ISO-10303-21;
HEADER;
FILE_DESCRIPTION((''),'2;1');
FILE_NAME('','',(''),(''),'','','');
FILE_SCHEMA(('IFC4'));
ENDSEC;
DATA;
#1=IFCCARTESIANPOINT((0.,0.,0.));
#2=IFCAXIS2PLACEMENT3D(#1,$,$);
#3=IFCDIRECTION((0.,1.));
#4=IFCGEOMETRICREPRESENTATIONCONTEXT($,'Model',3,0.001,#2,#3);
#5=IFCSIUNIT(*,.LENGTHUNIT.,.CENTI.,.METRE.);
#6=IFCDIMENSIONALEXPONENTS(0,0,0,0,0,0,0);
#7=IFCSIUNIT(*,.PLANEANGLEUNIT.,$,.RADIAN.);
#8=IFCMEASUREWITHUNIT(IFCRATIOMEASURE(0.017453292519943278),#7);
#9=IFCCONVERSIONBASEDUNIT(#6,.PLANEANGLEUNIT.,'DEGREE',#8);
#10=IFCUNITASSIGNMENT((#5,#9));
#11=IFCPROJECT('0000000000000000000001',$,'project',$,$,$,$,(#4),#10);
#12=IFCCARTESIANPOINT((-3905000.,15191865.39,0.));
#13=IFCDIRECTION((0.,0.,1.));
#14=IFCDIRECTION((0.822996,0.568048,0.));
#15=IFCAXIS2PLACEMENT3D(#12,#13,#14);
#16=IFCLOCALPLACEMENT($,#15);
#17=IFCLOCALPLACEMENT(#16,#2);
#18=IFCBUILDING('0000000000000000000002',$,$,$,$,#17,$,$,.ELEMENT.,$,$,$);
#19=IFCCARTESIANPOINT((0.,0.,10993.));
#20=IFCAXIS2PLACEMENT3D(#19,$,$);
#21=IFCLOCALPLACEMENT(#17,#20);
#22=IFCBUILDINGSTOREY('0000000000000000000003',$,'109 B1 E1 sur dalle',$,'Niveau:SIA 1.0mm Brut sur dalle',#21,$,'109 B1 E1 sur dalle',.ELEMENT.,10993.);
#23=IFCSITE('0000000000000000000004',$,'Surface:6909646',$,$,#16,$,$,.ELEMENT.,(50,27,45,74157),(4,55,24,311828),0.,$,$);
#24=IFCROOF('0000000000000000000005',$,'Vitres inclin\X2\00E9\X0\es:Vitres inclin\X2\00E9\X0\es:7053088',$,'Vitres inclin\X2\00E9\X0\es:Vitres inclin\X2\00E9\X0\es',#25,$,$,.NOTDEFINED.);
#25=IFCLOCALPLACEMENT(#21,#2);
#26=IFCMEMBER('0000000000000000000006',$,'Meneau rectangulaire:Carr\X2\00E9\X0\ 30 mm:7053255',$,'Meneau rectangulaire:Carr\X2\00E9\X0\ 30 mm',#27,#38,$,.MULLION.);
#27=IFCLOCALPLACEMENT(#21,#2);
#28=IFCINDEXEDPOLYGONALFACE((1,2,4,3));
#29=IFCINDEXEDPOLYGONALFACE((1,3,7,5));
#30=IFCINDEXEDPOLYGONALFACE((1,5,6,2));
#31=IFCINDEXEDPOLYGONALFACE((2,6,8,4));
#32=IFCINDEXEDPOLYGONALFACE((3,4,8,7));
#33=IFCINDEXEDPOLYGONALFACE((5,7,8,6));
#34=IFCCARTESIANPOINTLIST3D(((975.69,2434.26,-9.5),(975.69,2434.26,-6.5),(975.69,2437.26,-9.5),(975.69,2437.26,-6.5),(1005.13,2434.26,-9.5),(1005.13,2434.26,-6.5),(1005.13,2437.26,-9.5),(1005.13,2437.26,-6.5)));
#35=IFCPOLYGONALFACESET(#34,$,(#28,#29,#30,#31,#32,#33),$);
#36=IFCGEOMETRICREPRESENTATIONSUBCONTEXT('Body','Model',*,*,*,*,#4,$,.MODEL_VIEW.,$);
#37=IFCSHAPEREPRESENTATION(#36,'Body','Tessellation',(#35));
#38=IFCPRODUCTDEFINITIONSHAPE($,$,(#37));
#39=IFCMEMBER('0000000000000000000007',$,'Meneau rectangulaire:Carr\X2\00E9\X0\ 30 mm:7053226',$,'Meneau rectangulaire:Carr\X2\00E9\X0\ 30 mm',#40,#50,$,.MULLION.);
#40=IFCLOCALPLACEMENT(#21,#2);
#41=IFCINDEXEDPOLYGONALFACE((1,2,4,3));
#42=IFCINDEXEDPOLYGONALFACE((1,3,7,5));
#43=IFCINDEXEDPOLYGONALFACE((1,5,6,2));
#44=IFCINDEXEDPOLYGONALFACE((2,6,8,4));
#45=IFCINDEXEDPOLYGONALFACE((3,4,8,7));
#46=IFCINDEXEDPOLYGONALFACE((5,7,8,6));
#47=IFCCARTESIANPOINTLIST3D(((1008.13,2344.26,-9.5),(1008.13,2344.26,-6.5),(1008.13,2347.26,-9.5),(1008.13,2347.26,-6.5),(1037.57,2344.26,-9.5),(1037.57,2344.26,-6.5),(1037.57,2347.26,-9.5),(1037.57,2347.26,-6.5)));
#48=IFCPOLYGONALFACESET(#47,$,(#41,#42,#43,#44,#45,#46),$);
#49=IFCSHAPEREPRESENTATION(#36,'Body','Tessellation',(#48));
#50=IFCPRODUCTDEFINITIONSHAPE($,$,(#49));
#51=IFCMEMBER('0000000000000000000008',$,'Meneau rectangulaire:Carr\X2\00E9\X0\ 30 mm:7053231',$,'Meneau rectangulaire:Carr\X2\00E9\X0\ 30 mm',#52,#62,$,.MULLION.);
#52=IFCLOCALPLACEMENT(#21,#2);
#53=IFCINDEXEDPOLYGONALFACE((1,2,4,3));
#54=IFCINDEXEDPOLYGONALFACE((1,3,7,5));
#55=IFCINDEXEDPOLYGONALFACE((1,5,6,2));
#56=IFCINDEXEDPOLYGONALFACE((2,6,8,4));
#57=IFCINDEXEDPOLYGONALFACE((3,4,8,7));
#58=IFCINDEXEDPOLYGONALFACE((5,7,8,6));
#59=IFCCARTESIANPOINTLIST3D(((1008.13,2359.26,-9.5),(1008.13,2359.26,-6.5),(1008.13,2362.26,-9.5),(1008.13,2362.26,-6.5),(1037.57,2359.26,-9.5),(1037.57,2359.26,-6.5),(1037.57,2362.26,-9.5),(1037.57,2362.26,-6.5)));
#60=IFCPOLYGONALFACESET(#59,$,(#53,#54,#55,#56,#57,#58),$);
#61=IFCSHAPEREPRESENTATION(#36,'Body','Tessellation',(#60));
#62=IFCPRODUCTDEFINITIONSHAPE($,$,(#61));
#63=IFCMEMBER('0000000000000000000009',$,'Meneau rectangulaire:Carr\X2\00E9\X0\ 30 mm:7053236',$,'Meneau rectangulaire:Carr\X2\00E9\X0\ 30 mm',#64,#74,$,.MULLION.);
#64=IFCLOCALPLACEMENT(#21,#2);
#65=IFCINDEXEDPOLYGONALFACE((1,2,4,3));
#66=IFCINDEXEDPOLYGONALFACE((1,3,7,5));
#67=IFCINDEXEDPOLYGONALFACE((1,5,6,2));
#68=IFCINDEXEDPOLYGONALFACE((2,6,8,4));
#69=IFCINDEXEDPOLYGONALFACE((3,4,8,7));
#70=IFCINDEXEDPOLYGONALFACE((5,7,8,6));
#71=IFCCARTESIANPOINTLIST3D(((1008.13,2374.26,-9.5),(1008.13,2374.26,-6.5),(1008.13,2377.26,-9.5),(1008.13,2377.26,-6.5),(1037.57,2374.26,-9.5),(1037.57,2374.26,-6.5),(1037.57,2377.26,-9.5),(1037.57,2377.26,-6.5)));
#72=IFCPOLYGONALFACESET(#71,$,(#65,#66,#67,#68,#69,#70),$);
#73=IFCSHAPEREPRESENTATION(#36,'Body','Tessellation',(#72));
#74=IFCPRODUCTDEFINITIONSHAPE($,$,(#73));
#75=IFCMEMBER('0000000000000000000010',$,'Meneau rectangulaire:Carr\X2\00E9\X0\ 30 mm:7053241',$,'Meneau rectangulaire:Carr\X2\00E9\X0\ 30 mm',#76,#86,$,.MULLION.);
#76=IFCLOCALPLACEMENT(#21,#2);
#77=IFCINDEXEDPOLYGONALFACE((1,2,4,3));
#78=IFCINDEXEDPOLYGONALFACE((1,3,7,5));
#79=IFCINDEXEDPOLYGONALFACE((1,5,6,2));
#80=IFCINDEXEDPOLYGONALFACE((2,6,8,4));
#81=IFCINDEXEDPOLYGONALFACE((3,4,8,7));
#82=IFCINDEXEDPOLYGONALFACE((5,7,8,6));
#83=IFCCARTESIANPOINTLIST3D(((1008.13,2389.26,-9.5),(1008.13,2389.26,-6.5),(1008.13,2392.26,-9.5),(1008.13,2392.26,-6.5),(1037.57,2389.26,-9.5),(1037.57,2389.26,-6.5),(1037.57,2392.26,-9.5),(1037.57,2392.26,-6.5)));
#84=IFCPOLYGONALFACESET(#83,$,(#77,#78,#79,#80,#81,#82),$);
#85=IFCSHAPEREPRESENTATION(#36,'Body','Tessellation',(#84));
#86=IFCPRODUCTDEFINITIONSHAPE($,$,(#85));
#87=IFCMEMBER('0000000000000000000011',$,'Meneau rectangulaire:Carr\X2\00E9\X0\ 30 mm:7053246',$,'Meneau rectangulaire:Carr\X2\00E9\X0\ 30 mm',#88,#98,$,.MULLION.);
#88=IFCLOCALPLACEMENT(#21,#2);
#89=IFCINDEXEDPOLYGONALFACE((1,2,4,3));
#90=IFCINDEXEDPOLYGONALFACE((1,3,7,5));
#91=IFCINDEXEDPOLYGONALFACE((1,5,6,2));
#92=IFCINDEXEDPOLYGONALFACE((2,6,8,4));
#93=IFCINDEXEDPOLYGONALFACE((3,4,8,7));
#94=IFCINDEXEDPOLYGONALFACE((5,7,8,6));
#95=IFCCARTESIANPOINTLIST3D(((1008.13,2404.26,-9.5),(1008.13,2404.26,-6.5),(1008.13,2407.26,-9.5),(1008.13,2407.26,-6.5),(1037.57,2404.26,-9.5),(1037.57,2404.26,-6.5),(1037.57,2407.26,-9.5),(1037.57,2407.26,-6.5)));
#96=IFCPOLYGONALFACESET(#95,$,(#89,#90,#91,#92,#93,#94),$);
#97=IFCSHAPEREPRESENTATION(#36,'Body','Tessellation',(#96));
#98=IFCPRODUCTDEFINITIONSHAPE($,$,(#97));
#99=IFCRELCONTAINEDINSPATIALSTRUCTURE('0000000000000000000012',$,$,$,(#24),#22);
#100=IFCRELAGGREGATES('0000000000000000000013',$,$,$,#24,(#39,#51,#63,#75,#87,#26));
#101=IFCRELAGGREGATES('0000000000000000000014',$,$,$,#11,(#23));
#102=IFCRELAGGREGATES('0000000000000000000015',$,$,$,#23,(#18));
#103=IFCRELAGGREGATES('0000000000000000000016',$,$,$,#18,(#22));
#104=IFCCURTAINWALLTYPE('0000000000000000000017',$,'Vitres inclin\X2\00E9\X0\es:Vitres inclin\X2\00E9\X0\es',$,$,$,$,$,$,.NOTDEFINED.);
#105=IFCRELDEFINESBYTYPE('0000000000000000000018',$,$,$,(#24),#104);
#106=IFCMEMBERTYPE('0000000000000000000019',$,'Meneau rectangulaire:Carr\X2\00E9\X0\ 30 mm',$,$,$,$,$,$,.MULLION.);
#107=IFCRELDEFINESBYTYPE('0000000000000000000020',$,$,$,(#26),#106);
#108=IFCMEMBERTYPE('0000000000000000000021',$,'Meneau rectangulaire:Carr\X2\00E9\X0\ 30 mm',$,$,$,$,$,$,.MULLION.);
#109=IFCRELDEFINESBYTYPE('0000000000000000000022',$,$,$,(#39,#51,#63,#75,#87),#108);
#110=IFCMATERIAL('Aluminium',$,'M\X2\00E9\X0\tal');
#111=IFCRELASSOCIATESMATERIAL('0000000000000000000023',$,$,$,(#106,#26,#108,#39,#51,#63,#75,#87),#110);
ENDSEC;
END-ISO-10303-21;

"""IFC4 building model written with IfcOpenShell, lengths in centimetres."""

from ifc_helpers import new_model, entity, si_unit, converted_unit, direction, frame, origin, place, context, subcontext, project, spatial, indexed_curve, outline, extrude, source, transform, mapped, material, type_object, type_shapes, element, aggregate, save


model = new_model("IFC4")

# Units and contexts
model_context = context("Model", 3, precision=0.001, world=origin(), true_north=direction((0.0, 1.0)))
body_context = subcontext(model_context, "Body", "Model", "MODEL_VIEW")
ifc_project = project(units=[si_unit("LENGTHUNIT", "METRE", prefix="CENTI"), converted_unit("PLANEANGLEUNIT", "DEGREE", entity("IfcRatioMeasure", 0.017453292519943278), si_unit("PLANEANGLEUNIT", "RADIAN"), dimensions=[0, 0, 0, 0, 0, 0, 0])], contexts=[model_context])

# Site, building, storey
site_placement = place(None, frame((-3905000.0, 15191865.39, 0.0), z_axis=(0.0, 0.0, 1.0), x_axis=(0.822996, 0.568048, 0.0)))
site = spatial("IfcSite", under=ifc_project, at=site_placement, Name="Surface:6909646", CompositionType="ELEMENT", RefLatitude=(50, 27, 45, 74157), RefLongitude=(4, 55, 24, 311828), RefElevation=0.0)
building_placement = place(site_placement, origin())
building = spatial("IfcBuilding", under=site, at=building_placement, CompositionType="ELEMENT")
storey_placement = place(building_placement, frame((0.0, 0.0, 10993.0)))
storey = spatial("IfcBuildingStorey", under=building, at=storey_placement, Name="109 B1 E1 sur dalle", ObjectType="Niveau:SIA 1.0mm Brut sur dalle", LongName="109 B1 E1 sur dalle", CompositionType="ELEMENT", Elevation=10993.0)

# Roof, members
curtain_wall_type = type_object("IfcCurtainWallType", Name="Vitres inclinées:Vitres inclinées", PredefinedType="NOTDEFINED")
roof_placement = place(storey_placement, frame((0.0, 0.0, -10993.0)))
roof = element("IfcRoof", 1, at=roof_placement, inside=storey, type_object=curtain_wall_type, Name="Vitres inclinées:Vitres inclinées:7053088", ObjectType="Vitres inclinées:Vitres inclinées", PredefinedType="NOTDEFINED")
ifc_material = material(Name="Aluminium", Category="Métal")
member_type_1 = type_object("IfcMemberType", Name="Meneau rectangulaire:Carré 30 mm", PredefinedType="MULLION", material=ifc_material)
shared_shape_1 = source(origin(), body_context, "Body", "SweptSolid", [
    extrude(outline(indexed_curve([(-1.5, -1.5), (1.5, -1.5), (1.5, 1.5), (-1.5, 1.5), (-1.5, -1.5)], self_intersect=False)), frame((0.0, 0.0, -29.44), z_axis=(0.0, 0.0, 1.0), x_axis=(0.0, -1.0, 0.0)), (0.0, 0.0, 1.0), 29.44),
])
type_shapes(member_type_1, [shared_shape_1])
member_1_placement = place(roof_placement, frame((975.69, 2435.76, 10985.0), z_axis=(-1.0, 0.0, 0.0), x_axis=(0.0, 1.0, 0.0)))
member_1 = element("IfcMember", 2, at=member_1_placement, type_object=member_type_1, material=ifc_material, Name="Meneau rectangulaire:Carré 30 mm:7053255", ObjectType="Meneau rectangulaire:Carré 30 mm", PredefinedType="MULLION", context=body_context, shape_type="MappedRepresentation", body=[
    mapped(shared_shape_1, transform((0.0, 0.0, 0.0), scale=1.0)),
])
member_type_2 = type_object("IfcMemberType", Name="Meneau rectangulaire:Carré 30 mm", PredefinedType="MULLION", material=ifc_material)
shared_shape_2 = source(origin(), body_context, "Body", "SweptSolid", [
    extrude(outline(indexed_curve([(-1.5, -1.5), (1.5, -1.5), (1.5, 1.5), (-1.5, 1.5), (-1.5, -1.5)], self_intersect=False)), frame((0.0, 0.0, -29.44), z_axis=(0.0, 0.0, 1.0), x_axis=(0.0, -1.0, 0.0)), (0.0, 0.0, 1.0), 29.44),
])
type_shapes(member_type_2, [shared_shape_2])
member_2_placement = place(roof_placement, frame((1008.13, 2345.76, 10985.0), z_axis=(-1.0, 0.0, 0.0), x_axis=(0.0, 1.0, 0.0)))
member_2 = element("IfcMember", 3, at=member_2_placement, type_object=member_type_2, material=ifc_material, Name="Meneau rectangulaire:Carré 30 mm:7053226", ObjectType="Meneau rectangulaire:Carré 30 mm", PredefinedType="MULLION", context=body_context, shape_type="MappedRepresentation", body=[
    mapped(shared_shape_2, transform((0.0, 0.0, 0.0), scale=1.0)),
])
member_3_placement = place(roof_placement, frame((1008.13, 2360.76, 10985.0), z_axis=(-1.0, 0.0, 0.0), x_axis=(0.0, 1.0, 0.0)))
member_3 = element("IfcMember", 4, at=member_3_placement, type_object=member_type_2, material=ifc_material, Name="Meneau rectangulaire:Carré 30 mm:7053231", ObjectType="Meneau rectangulaire:Carré 30 mm", PredefinedType="MULLION", context=body_context, shape_type="MappedRepresentation", body=[
    mapped(shared_shape_2, transform((0.0, 0.0, 0.0), scale=1.0)),
])
member_4_placement = place(roof_placement, frame((1008.13, 2375.76, 10985.0), z_axis=(-1.0, 0.0, 0.0), x_axis=(0.0, 1.0, 0.0)))
member_4 = element("IfcMember", 5, at=member_4_placement, type_object=member_type_2, material=ifc_material, Name="Meneau rectangulaire:Carré 30 mm:7053236", ObjectType="Meneau rectangulaire:Carré 30 mm", PredefinedType="MULLION", context=body_context, shape_type="MappedRepresentation", body=[
    mapped(shared_shape_2, transform((0.0, 0.0, 0.0), scale=1.0)),
])
member_5_placement = place(roof_placement, frame((1008.13, 2390.76, 10985.0), z_axis=(-1.0, 0.0, 0.0), x_axis=(0.0, 1.0, 0.0)))
member_5 = element("IfcMember", 6, at=member_5_placement, type_object=member_type_2, material=ifc_material, Name="Meneau rectangulaire:Carré 30 mm:7053241", ObjectType="Meneau rectangulaire:Carré 30 mm", PredefinedType="MULLION", context=body_context, shape_type="MappedRepresentation", body=[
    mapped(shared_shape_2, transform((0.0, 0.0, 0.0), scale=1.0)),
])
member_6_placement = place(roof_placement, frame((1008.13, 2405.76, 10985.0), z_axis=(-1.0, 0.0, 0.0), x_axis=(0.0, 1.0, 0.0)))
member_6 = element("IfcMember", 7, at=member_6_placement, type_object=member_type_2, material=ifc_material, Name="Meneau rectangulaire:Carré 30 mm:7053246", ObjectType="Meneau rectangulaire:Carré 30 mm", PredefinedType="MULLION", context=body_context, shape_type="MappedRepresentation", body=[
    mapped(shared_shape_2, transform((0.0, 0.0, 0.0), scale=1.0)),
])
aggregate(roof, [member_2, member_3, member_4, member_5, member_6, member_1])

save(model, "model.ifc")
